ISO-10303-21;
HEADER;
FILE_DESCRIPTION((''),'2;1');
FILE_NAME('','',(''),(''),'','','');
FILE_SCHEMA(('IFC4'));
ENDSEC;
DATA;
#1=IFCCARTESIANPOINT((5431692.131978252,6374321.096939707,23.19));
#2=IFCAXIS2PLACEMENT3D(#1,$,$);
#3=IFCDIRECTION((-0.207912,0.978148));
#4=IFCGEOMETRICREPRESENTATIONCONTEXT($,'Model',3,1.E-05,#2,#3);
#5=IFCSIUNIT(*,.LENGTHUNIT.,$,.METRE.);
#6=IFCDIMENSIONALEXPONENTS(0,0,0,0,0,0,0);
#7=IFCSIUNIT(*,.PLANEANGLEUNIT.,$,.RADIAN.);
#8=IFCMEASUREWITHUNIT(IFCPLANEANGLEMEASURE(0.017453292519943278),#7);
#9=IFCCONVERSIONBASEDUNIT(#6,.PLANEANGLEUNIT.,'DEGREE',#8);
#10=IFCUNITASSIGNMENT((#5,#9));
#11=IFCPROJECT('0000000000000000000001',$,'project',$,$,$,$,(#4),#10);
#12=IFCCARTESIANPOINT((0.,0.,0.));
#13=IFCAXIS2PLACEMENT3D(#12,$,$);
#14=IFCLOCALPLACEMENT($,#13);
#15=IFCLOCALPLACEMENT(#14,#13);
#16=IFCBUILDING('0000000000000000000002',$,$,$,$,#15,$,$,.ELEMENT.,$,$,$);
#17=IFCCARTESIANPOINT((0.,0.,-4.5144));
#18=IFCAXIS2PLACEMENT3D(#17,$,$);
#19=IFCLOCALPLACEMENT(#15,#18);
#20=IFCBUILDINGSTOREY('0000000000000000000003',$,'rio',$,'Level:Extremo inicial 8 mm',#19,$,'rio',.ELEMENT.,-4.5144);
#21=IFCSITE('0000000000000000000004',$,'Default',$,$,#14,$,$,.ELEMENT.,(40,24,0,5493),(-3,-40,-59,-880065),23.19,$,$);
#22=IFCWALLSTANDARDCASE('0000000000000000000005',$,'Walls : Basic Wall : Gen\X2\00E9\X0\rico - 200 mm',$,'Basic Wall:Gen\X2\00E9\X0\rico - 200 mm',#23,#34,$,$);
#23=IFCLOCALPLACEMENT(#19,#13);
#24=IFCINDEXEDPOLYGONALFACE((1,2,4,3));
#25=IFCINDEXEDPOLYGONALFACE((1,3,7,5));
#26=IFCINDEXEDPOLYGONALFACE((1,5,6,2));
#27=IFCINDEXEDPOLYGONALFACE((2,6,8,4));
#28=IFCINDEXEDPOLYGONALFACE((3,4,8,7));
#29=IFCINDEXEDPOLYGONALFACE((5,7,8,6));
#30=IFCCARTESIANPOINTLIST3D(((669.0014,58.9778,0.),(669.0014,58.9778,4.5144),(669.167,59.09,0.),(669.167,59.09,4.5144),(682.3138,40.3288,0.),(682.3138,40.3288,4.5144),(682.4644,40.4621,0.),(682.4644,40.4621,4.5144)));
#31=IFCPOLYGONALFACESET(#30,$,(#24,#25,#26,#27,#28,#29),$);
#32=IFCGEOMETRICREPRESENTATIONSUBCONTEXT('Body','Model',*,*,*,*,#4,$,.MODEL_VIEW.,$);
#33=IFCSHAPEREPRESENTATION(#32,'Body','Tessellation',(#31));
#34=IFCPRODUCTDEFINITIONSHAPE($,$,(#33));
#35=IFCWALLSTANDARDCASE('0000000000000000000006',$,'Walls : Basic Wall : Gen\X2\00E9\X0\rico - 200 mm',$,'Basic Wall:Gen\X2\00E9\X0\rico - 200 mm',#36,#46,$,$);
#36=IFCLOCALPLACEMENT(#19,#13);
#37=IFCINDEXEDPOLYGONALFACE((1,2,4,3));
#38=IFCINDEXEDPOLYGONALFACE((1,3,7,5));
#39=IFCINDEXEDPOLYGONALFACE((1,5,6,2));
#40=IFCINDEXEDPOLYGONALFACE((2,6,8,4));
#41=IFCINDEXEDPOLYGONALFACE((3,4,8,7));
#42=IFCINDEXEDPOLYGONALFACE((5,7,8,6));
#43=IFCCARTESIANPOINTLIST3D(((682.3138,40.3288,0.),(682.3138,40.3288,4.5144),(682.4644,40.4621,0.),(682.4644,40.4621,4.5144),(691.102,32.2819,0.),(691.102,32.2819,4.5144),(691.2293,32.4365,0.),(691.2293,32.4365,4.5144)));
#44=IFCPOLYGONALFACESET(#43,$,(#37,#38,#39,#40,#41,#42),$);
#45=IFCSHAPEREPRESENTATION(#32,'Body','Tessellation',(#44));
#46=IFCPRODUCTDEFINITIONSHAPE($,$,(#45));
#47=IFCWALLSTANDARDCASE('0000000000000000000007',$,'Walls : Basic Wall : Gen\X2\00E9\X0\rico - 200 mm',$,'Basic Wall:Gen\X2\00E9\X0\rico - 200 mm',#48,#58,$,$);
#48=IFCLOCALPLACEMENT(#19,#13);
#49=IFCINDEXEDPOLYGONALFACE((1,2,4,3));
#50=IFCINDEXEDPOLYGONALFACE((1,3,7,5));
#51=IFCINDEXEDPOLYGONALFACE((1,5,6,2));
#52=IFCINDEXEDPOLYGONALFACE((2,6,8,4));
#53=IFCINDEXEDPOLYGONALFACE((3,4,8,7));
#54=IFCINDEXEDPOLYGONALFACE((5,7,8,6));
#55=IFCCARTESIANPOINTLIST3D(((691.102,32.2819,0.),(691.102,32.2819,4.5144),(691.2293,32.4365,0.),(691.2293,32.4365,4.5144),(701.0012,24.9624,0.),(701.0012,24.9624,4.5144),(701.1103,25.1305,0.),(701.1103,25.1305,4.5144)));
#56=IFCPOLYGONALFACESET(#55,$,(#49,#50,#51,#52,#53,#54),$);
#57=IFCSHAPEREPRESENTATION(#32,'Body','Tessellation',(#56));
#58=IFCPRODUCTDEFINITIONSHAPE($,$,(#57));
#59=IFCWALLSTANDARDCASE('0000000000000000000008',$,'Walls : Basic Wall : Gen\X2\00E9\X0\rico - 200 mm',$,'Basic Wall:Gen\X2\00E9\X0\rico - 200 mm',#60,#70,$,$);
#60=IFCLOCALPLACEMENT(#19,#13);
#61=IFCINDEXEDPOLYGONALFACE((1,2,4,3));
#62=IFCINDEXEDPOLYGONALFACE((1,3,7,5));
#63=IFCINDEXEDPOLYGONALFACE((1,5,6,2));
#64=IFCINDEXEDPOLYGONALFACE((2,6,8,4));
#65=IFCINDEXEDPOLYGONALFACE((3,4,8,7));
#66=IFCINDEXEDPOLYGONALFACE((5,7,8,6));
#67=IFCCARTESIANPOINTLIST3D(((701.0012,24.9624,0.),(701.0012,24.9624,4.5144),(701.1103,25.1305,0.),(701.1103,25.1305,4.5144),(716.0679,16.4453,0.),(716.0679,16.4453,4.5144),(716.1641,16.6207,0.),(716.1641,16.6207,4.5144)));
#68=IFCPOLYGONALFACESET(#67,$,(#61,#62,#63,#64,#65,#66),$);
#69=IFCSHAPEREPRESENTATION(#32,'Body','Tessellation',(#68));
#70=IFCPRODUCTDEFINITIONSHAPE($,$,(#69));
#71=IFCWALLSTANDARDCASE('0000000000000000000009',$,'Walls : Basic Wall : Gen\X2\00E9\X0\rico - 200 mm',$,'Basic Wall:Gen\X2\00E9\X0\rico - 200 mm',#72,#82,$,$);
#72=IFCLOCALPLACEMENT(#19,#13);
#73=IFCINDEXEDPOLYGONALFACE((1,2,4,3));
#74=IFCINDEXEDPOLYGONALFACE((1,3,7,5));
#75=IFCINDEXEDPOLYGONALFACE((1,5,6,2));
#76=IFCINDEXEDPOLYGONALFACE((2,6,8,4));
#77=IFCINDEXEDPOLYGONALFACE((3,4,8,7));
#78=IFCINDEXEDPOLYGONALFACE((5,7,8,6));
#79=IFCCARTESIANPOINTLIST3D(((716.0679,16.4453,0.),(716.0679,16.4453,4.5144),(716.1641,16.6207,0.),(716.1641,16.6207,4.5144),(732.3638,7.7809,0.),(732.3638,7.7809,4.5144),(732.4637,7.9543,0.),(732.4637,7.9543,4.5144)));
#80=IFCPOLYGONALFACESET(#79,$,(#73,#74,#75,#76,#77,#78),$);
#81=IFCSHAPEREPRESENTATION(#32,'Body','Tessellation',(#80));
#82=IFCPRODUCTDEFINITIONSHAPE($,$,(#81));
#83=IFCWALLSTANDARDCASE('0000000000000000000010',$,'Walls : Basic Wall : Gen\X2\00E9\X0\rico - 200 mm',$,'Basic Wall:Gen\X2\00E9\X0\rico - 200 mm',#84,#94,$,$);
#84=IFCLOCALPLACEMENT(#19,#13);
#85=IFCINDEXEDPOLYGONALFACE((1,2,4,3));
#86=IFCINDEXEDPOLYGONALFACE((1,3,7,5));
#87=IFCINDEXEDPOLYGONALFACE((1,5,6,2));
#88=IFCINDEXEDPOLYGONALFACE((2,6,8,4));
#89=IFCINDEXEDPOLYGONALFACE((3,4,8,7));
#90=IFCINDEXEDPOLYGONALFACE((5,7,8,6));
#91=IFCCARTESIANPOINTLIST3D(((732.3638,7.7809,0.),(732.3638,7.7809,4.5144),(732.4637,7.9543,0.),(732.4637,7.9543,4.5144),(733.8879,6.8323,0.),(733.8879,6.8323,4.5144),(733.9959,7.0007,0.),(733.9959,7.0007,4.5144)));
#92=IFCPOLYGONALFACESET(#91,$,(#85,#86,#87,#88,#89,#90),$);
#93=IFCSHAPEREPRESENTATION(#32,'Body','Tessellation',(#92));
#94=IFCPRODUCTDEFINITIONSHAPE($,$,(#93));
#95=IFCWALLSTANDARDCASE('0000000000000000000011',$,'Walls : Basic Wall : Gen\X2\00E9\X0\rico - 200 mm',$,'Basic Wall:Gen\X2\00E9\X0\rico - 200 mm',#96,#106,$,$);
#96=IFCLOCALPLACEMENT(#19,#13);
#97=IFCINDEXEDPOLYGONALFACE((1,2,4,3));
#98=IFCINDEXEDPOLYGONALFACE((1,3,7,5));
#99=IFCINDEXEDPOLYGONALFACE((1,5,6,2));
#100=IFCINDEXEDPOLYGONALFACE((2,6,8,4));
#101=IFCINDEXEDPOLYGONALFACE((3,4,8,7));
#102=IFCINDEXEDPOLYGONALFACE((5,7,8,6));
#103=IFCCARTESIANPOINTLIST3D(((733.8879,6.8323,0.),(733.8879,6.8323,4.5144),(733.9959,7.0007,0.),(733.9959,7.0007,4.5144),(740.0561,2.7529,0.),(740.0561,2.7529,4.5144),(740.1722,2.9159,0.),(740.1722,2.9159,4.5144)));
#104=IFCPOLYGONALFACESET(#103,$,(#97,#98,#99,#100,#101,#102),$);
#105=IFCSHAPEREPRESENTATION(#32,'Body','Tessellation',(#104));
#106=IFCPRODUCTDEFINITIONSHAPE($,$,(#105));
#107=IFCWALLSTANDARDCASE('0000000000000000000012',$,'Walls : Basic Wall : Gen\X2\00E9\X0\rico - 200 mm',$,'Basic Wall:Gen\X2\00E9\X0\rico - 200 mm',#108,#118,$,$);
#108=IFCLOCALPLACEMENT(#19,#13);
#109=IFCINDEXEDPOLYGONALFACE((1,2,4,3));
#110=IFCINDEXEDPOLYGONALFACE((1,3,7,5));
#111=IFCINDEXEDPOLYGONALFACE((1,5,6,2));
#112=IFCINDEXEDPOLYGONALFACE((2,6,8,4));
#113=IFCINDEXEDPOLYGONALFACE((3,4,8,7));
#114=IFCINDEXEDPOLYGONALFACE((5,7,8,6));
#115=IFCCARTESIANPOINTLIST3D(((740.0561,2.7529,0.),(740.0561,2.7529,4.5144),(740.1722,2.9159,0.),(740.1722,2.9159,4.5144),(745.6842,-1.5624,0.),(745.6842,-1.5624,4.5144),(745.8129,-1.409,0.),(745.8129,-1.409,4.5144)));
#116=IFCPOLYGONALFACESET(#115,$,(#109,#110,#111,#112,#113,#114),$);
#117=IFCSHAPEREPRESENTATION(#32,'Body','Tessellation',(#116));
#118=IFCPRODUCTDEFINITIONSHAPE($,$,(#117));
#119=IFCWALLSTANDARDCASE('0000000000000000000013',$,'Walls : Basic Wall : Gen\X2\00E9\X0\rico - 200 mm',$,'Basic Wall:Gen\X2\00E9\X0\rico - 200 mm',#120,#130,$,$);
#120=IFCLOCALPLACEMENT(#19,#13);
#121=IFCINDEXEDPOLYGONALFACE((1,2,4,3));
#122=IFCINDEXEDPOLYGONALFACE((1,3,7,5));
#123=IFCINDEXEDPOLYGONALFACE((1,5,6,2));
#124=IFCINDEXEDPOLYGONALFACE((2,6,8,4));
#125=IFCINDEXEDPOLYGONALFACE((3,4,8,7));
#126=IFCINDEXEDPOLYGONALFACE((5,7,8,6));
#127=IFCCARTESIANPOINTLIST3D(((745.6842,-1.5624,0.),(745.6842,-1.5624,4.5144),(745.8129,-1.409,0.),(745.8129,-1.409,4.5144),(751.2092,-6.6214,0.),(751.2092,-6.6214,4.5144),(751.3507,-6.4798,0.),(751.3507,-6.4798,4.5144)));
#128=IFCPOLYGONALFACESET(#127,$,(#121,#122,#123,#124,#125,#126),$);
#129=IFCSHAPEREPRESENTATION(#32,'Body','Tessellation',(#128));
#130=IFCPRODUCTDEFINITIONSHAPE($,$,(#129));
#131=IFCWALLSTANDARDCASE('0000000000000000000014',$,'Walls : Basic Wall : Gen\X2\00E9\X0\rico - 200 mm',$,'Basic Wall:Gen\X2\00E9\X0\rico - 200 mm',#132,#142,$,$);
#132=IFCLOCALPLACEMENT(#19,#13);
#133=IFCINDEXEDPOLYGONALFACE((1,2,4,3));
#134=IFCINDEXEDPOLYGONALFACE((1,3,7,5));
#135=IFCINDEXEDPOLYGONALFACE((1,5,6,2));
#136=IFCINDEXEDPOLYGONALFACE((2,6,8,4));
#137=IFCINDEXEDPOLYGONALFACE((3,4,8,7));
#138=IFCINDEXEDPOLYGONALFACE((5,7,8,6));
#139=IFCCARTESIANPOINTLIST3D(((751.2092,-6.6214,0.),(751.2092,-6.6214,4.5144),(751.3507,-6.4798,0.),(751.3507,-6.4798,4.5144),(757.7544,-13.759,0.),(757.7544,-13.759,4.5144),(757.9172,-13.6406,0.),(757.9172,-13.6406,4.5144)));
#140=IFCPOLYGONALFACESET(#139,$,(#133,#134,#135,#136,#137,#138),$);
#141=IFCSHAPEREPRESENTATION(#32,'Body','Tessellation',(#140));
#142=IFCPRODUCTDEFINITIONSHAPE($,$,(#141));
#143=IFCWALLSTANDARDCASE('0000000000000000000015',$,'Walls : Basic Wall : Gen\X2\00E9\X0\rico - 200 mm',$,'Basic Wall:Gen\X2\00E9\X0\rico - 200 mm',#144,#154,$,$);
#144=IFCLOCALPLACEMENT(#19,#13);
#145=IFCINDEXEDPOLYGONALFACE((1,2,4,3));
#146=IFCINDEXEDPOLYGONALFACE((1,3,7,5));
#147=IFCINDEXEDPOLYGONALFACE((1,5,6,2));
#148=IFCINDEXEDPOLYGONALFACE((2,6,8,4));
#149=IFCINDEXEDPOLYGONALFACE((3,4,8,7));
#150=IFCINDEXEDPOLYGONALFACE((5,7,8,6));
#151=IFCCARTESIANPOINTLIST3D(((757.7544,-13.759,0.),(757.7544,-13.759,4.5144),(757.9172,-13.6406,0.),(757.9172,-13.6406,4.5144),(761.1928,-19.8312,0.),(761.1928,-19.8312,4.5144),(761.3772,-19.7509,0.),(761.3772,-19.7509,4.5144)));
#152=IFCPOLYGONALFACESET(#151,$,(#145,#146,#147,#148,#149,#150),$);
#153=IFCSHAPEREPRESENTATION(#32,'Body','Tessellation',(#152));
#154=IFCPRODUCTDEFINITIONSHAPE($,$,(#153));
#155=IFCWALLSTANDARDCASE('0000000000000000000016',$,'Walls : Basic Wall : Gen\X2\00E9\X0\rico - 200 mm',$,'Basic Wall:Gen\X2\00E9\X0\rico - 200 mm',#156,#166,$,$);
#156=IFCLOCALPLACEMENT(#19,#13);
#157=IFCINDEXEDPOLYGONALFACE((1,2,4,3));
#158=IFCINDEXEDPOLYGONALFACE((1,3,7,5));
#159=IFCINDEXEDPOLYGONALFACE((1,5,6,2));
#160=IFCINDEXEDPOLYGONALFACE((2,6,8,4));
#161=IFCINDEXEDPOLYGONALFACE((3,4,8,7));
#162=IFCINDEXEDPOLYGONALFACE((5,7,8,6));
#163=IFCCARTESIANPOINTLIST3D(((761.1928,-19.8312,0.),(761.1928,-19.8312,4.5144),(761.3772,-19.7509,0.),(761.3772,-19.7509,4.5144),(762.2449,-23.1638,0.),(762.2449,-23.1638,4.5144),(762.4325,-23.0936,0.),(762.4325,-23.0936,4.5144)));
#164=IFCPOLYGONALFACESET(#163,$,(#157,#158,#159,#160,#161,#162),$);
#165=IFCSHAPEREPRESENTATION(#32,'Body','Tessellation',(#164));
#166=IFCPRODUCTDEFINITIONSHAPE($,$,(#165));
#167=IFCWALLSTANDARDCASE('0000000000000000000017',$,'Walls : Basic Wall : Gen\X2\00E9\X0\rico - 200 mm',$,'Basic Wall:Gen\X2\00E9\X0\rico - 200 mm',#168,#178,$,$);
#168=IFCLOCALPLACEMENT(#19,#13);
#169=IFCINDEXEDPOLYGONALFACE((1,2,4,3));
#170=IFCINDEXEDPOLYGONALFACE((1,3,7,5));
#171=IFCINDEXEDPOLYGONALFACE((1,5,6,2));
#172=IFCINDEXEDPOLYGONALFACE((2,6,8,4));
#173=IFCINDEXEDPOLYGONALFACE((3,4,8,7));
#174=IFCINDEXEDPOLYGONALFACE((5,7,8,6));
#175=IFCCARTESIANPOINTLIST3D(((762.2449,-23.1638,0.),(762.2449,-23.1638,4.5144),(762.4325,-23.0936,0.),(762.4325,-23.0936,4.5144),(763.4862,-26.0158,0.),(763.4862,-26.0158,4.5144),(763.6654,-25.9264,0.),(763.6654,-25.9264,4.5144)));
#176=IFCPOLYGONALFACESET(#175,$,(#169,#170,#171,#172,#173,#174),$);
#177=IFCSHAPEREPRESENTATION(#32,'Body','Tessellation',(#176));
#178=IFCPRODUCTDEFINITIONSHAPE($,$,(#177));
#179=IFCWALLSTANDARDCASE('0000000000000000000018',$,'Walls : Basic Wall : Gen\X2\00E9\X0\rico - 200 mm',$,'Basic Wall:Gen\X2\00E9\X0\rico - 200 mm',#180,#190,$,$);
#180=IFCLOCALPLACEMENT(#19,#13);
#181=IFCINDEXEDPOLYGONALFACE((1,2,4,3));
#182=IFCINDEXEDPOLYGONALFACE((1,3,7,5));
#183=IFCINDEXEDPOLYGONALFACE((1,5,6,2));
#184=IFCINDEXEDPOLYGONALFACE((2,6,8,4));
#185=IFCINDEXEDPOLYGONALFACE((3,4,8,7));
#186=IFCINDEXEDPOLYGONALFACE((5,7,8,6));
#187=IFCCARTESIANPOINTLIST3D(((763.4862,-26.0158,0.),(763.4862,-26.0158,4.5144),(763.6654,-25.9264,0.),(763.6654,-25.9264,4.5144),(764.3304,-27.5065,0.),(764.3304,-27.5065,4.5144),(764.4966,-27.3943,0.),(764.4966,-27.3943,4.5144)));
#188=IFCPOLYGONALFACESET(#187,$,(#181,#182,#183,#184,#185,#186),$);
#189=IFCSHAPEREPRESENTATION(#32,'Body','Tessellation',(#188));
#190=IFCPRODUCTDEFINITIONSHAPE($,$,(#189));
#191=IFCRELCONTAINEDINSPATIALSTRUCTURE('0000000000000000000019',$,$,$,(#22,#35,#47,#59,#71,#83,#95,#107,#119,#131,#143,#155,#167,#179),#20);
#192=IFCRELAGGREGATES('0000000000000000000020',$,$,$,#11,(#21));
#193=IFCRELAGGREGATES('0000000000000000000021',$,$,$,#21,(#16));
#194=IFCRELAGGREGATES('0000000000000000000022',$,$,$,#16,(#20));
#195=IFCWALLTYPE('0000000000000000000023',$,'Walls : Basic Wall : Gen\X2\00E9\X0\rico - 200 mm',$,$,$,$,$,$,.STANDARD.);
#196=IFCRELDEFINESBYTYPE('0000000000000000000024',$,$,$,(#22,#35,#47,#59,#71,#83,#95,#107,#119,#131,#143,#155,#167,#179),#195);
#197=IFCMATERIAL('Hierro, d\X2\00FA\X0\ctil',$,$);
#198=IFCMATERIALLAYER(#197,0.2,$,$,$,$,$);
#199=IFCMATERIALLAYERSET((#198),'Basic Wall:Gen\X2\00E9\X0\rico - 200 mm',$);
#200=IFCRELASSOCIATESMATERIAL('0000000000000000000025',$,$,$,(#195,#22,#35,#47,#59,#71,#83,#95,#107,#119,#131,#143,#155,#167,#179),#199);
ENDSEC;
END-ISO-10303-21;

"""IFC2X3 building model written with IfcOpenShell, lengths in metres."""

from ifc_helpers import new_model, entity, si_unit, converted_unit, direction, frame, origin, place, context, subcontext, project, spatial, polyline, outline, extrude, material, layer, layer_set, layer_usage, type_object, element, save


model = new_model("IFC2X3")

# Units and contexts
model_context = context("Model", 3, precision=1e-05, world=frame((5431692.131978252, 6374321.096939707, 23.19)), true_north=direction((-0.207912, 0.978148)))
body_context = subcontext(model_context, "Body", "Model", "MODEL_VIEW")
ifc_project = project(units=[si_unit("LENGTHUNIT", "METRE"), converted_unit("PLANEANGLEUNIT", "DEGREE", entity("IfcPlaneAngleMeasure", 0.017453292519943278), si_unit("PLANEANGLEUNIT", "RADIAN"), dimensions=[0, 0, 0, 0, 0, 0, 0])], contexts=[model_context])

# Site, building, storey
site_placement = place(None, origin())
site = spatial("IfcSite", under=ifc_project, at=site_placement, Name="Default", CompositionType="ELEMENT", RefLatitude=(40, 24, 0, 5493), RefLongitude=(-3, -40, -59, -880065), RefElevation=23.19)
building_placement = place(site_placement, origin())
building = spatial("IfcBuilding", under=site, at=building_placement, CompositionType="ELEMENT")
storey_placement = place(building_placement, frame((0.0, 0.0, -4.5144)))
storey = spatial("IfcBuildingStorey", under=building, at=storey_placement, Name="rio", ObjectType="Level:Extremo inicial 8 mm", LongName="rio", CompositionType="ELEMENT", Elevation=-4.5144)

# Walls
ifc_material = material(Name="Hierro, dúctil")
ifc_layer = layer(ifc_material, 0.2)
ifc_layer_set = layer_set([ifc_layer], Name="Basic Wall:Genérico - 200 mm")
ifc_layer_usage_1 = layer_usage(ifc_layer_set, "AXIS2", "NEGATIVE", 0.1)
wall_type = type_object("IfcWallType", Name="Walls : Basic Wall : Genérico - 200 mm", PredefinedType="STANDARD", material=ifc_layer_set)
wall_1_placement = place(storey_placement, frame((669.0828, 59.0359, 0.0), z_axis=(0.0, 0.0, 1.0), x_axis=(0.581, -0.813903, 0.0)))
element("IfcWallStandardCase", 1, at=wall_1_placement, inside=storey, type_object=wall_type, material=ifc_layer_usage_1, Name="Walls : Basic Wall : Genérico - 200 mm", ObjectType="Basic Wall:Genérico - 200 mm", context=body_context, shape_type="SweptSolid", body=[
    extrude(outline(polyline([(22.913, -0.1), (22.8919, 0.1), (0.0049, 0.1), (0.0, -0.1), (22.913, -0.1)])), origin(), (0.0, 0.0, 1.0), 4.5144),
])
ifc_layer_usage_2 = layer_usage(ifc_layer_set, "AXIS2", "NEGATIVE", 0.1)
wall_2_placement = place(storey_placement, frame((682.3813, 40.4026, 0.0), z_axis=(0.0, 0.0, 1.0), x_axis=(0.737524, -0.675321, 0.0)))
element("IfcWallStandardCase", 2, at=wall_2_placement, inside=storey, type_object=wall_type, material=ifc_layer_usage_2, Name="Walls : Basic Wall : Genérico - 200 mm", ObjectType="Basic Wall:Genérico - 200 mm", context=body_context, shape_type="SweptSolid", body=[
    extrude(outline(polyline([(11.9158, -0.1), (11.9053, 0.1), (0.021, 0.1), (0.0, -0.1), (11.9158, -0.1)])), origin(), (0.0, 0.0, 1.0), 4.5144),
])
ifc_layer_usage_3 = layer_usage(ifc_layer_set, "AXIS2", "NEGATIVE", 0.1)
wall_3_placement = place(storey_placement, frame((691.1614, 32.3623, 0.0), z_axis=(0.0, 0.0, 1.0), x_axis=(0.804074, -0.594529, 0.0)))
element("IfcWallStandardCase", 3, at=wall_3_placement, inside=storey, type_object=wall_type, material=ifc_layer_usage_3, Name="Walls : Basic Wall : Genérico - 200 mm", ObjectType="Basic Wall:Genérico - 200 mm", context=body_context, shape_type="SweptSolid", body=[
    extrude(outline(polyline([(12.3114, -0.1), (12.2991, 0.1), (0.0105, 0.1), (0.0, -0.1), (12.3114, -0.1)])), origin(), (0.0, 0.0, 1.0), 4.5144),
])
ifc_layer_usage_4 = layer_usage(ifc_layer_set, "AXIS2", "NEGATIVE", 0.1)
wall_4_placement = place(storey_placement, frame((701.0504, 25.0495, 0.0), z_axis=(0.0, 0.0, 1.0), x_axis=(0.870535, -0.492106, 0.0)))
element("IfcWallStandardCase", 4, at=wall_4_placement, inside=storey, type_object=wall_type, material=ifc_layer_usage_4, Name="Walls : Basic Wall : Genérico - 200 mm", ObjectType="Basic Wall:Genérico - 200 mm", context=body_context, shape_type="SweptSolid", body=[
    extrude(outline(polyline([(17.3074, -0.1), (17.3048, 0.1), (0.0122, 0.1), (0.0, -0.1), (17.3074, -0.1)])), origin(), (0.0, 0.0, 1.0), 4.5144),
])
ifc_layer_usage_5 = layer_usage(ifc_layer_set, "AXIS2", "NEGATIVE", 0.1)
wall_5_placement = place(storey_placement, frame((716.1149, 16.5336, 0.0), z_axis=(0.0, 0.0, 1.0), x_axis=(0.882953, -0.469461, 0.0)))
element("IfcWallStandardCase", 5, at=wall_5_placement, inside=storey, type_object=wall_type, material=ifc_layer_usage_5, Name="Walls : Basic Wall : Genérico - 200 mm", ObjectType="Basic Wall:Genérico - 200 mm", context=body_context, shape_type="SweptSolid", body=[
    extrude(outline(polyline([(18.4561, -0.1), (18.4629, 0.1), (0.0026, 0.1), (0.0, -0.1), (18.4561, -0.1)])), origin(), (0.0, 0.0, 1.0), 4.5144),
])
ifc_layer_usage_6 = layer_usage(ifc_layer_set, "AXIS2", "NEGATIVE", 0.1)
wall_6_placement = place(storey_placement, frame((732.4108, 7.8694, 0.0), z_axis=(0.0, 0.0, 1.0), x_axis=(0.848993, -0.528404, 0.0)))
element("IfcWallStandardCase", 6, at=wall_6_placement, inside=storey, type_object=wall_type, material=ifc_layer_usage_6, Name="Walls : Basic Wall : Genérico - 200 mm", ObjectType="Basic Wall:Genérico - 200 mm", context=body_context, shape_type="SweptSolid", body=[
    extrude(outline(polyline([(1.802, -0.1), (1.8048, 0.1), (0.0, 0.1), (0.0068, -0.1), (1.802, -0.1)])), origin(), (0.0, 0.0, 1.0), 4.5144),
])
ifc_layer_usage_7 = layer_usage(ifc_layer_set, "AXIS2", "NEGATIVE", 0.1)
wall_7_placement = place(storey_placement, frame((733.9408, 6.9173, 0.0), z_axis=(0.0, 0.0, 1.0), x_axis=(0.834087, -0.551632, 0.0)))
element("IfcWallStandardCase", 7, at=wall_7_placement, inside=storey, type_object=wall_type, material=ifc_layer_usage_7, Name="Walls : Basic Wall : Genérico - 200 mm", ObjectType="Basic Wall:Genérico - 200 mm", context=body_context, shape_type="SweptSolid", body=[
    extrude(outline(polyline([(7.3979, -0.1), (7.4049, 0.1), (0.0, 0.1), (0.0028, -0.1), (7.3979, -0.1)])), origin(), (0.0, 0.0, 1.0), 4.5144),
])
ifc_layer_usage_8 = layer_usage(ifc_layer_set, "AXIS2", "NEGATIVE", 0.1)
wall_8_placement = place(storey_placement, frame((740.1114, 2.8366, 0.0), z_axis=(0.0, 0.0, 1.0), x_axis=(0.793576, -0.608472, 0.0)))
element("IfcWallStandardCase", 8, at=wall_8_placement, inside=storey, type_object=wall_type, material=ifc_layer_usage_8, Name="Walls : Basic Wall : Genérico - 200 mm", ObjectType="Basic Wall:Genérico - 200 mm", context=body_context, shape_type="SweptSolid", body=[
    extrude(outline(polyline([(7.0991, -0.1), (7.1079, 0.1), (0.0, 0.1), (0.007, -0.1), (7.0991, -0.1)])), origin(), (0.0, 0.0, 1.0), 4.5144),
])
ifc_layer_usage_9 = layer_usage(ifc_layer_set, "AXIS2", "NEGATIVE", 0.1)
wall_9_placement = place(storey_placement, frame((745.7453, -1.4828, 0.0), z_axis=(0.0, 0.0, 1.0), x_axis=(0.737524, -0.675321, 0.0)))
element("IfcWallStandardCase", 9, at=wall_9_placement, inside=storey, type_object=wall_type, material=ifc_layer_usage_9, Name="Walls : Basic Wall : Genérico - 200 mm", ObjectType="Basic Wall:Genérico - 200 mm", context=body_context, shape_type="SweptSolid", body=[
    extrude(outline(polyline([(7.5, -0.1), (7.5087, 0.1), (0.0, 0.1), (0.0087, -0.1), (7.5, -0.1)])), origin(), (0.0, 0.0, 1.0), 4.5144),
])
ifc_layer_usage_10 = layer_usage(ifc_layer_set, "AXIS2", "NEGATIVE", 0.1)
wall_10_placement = place(storey_placement, frame((751.277, -6.5474, 0.0), z_axis=(0.0, 0.0, 1.0), x_axis=(0.675859, -0.737031, 0.0)))
element("IfcWallStandardCase", 10, at=wall_10_placement, inside=storey, type_object=wall_type, material=ifc_layer_usage_10, Name="Walls : Basic Wall : Genérico - 200 mm", ObjectType="Basic Wall:Genérico - 200 mm", context=body_context, shape_type="SweptSolid", body=[
    extrude(outline(polyline([(9.693, -0.1), (9.7158, 0.1), (0.0, 0.1), (0.0087, -0.1), (9.693, -0.1)])), origin(), (0.0, 0.0, 1.0), 4.5144),
])
ifc_layer_usage_11 = layer_usage(ifc_layer_set, "AXIS2", "NEGATIVE", 0.1)
wall_11_placement = place(storey_placement, frame((757.8302, -13.6899, 0.0), z_axis=(0.0, 0.0, 1.0), x_axis=(0.492741, -0.870176, 0.0)))
element("IfcWallStandardCase", 11, at=wall_11_placement, inside=storey, type_object=wall_type, material=ifc_layer_usage_11, Name="Walls : Basic Wall : Genérico - 200 mm", ObjectType="Basic Wall:Genérico - 200 mm", context=body_context, shape_type="SweptSolid", body=[
    extrude(outline(polyline([(7.0009, -0.1), (7.0219, 0.1), (0.0, 0.1), (0.0228, -0.1), (7.0009, -0.1)])), origin(), (0.0, 0.0, 1.0), 4.5144),
])
ifc_layer_usage_12 = layer_usage(ifc_layer_set, "AXIS2", "NEGATIVE", 0.1)
wall_12_placement = place(storey_placement, frame((761.2818, -19.781, 0.0), z_axis=(0.0, 0.0, 1.0), x_axis=(0.301054, -0.953607, 0.0)))
element("IfcWallStandardCase", 12, at=wall_12_placement, inside=storey, type_object=wall_type, material=ifc_layer_usage_12, Name="Walls : Basic Wall : Genérico - 200 mm", ObjectType="Basic Wall:Genérico - 200 mm", context=body_context, shape_type="SweptSolid", body=[
    extrude(outline(polyline([(3.5158, -0.1), (3.5053, 0.1), (0.0, 0.1), (0.021, -0.1), (3.5158, -0.1)])), origin(), (0.0, 0.0, 1.0), 4.5144),
])
ifc_layer_usage_13 = layer_usage(ifc_layer_set, "AXIS2", "NEGATIVE", 0.1)
wall_13_placement = place(storey_placement, frame((762.3366, -23.1239, 0.0), z_axis=(0.0, 0.0, 1.0), x_axis=(0.399084, -0.916914, 0.0)))
element("IfcWallStandardCase", 13, at=wall_13_placement, inside=storey, type_object=wall_type, material=ifc_layer_usage_13, Name="Walls : Basic Wall : Genérico - 200 mm", ObjectType="Basic Wall:Genérico - 200 mm", context=body_context, shape_type="SweptSolid", body=[
    extrude(outline(polyline([(3.1105, -0.1), (3.1, 0.1), (0.0105, 0.1), (0.0, -0.1), (3.1105, -0.1)])), origin(), (0.0, 0.0, 1.0), 4.5144),
])
ifc_layer_usage_14 = layer_usage(ifc_layer_set, "AXIS2", "NEGATIVE", 0.1)
wall_14_placement = place(storey_placement, frame((763.5733, -25.9666, 0.0), z_axis=(0.0, 0.0, 1.0), x_axis=(0.492741, -0.870176, 0.0)))
element("IfcWallStandardCase", 14, at=wall_14_placement, inside=storey, type_object=wall_type, material=ifc_layer_usage_14, Name="Walls : Basic Wall : Genérico - 200 mm", ObjectType="Basic Wall:Genérico - 200 mm", context=body_context, shape_type="SweptSolid", body=[
    extrude(outline(polyline([(1.7131, -0.1), (1.6974, 0.1), (0.0105, 0.1), (0.0, -0.1), (1.7131, -0.1)])), origin(), (0.0, 0.0, 1.0), 4.5144),
])

save(model, "model.ifc")
